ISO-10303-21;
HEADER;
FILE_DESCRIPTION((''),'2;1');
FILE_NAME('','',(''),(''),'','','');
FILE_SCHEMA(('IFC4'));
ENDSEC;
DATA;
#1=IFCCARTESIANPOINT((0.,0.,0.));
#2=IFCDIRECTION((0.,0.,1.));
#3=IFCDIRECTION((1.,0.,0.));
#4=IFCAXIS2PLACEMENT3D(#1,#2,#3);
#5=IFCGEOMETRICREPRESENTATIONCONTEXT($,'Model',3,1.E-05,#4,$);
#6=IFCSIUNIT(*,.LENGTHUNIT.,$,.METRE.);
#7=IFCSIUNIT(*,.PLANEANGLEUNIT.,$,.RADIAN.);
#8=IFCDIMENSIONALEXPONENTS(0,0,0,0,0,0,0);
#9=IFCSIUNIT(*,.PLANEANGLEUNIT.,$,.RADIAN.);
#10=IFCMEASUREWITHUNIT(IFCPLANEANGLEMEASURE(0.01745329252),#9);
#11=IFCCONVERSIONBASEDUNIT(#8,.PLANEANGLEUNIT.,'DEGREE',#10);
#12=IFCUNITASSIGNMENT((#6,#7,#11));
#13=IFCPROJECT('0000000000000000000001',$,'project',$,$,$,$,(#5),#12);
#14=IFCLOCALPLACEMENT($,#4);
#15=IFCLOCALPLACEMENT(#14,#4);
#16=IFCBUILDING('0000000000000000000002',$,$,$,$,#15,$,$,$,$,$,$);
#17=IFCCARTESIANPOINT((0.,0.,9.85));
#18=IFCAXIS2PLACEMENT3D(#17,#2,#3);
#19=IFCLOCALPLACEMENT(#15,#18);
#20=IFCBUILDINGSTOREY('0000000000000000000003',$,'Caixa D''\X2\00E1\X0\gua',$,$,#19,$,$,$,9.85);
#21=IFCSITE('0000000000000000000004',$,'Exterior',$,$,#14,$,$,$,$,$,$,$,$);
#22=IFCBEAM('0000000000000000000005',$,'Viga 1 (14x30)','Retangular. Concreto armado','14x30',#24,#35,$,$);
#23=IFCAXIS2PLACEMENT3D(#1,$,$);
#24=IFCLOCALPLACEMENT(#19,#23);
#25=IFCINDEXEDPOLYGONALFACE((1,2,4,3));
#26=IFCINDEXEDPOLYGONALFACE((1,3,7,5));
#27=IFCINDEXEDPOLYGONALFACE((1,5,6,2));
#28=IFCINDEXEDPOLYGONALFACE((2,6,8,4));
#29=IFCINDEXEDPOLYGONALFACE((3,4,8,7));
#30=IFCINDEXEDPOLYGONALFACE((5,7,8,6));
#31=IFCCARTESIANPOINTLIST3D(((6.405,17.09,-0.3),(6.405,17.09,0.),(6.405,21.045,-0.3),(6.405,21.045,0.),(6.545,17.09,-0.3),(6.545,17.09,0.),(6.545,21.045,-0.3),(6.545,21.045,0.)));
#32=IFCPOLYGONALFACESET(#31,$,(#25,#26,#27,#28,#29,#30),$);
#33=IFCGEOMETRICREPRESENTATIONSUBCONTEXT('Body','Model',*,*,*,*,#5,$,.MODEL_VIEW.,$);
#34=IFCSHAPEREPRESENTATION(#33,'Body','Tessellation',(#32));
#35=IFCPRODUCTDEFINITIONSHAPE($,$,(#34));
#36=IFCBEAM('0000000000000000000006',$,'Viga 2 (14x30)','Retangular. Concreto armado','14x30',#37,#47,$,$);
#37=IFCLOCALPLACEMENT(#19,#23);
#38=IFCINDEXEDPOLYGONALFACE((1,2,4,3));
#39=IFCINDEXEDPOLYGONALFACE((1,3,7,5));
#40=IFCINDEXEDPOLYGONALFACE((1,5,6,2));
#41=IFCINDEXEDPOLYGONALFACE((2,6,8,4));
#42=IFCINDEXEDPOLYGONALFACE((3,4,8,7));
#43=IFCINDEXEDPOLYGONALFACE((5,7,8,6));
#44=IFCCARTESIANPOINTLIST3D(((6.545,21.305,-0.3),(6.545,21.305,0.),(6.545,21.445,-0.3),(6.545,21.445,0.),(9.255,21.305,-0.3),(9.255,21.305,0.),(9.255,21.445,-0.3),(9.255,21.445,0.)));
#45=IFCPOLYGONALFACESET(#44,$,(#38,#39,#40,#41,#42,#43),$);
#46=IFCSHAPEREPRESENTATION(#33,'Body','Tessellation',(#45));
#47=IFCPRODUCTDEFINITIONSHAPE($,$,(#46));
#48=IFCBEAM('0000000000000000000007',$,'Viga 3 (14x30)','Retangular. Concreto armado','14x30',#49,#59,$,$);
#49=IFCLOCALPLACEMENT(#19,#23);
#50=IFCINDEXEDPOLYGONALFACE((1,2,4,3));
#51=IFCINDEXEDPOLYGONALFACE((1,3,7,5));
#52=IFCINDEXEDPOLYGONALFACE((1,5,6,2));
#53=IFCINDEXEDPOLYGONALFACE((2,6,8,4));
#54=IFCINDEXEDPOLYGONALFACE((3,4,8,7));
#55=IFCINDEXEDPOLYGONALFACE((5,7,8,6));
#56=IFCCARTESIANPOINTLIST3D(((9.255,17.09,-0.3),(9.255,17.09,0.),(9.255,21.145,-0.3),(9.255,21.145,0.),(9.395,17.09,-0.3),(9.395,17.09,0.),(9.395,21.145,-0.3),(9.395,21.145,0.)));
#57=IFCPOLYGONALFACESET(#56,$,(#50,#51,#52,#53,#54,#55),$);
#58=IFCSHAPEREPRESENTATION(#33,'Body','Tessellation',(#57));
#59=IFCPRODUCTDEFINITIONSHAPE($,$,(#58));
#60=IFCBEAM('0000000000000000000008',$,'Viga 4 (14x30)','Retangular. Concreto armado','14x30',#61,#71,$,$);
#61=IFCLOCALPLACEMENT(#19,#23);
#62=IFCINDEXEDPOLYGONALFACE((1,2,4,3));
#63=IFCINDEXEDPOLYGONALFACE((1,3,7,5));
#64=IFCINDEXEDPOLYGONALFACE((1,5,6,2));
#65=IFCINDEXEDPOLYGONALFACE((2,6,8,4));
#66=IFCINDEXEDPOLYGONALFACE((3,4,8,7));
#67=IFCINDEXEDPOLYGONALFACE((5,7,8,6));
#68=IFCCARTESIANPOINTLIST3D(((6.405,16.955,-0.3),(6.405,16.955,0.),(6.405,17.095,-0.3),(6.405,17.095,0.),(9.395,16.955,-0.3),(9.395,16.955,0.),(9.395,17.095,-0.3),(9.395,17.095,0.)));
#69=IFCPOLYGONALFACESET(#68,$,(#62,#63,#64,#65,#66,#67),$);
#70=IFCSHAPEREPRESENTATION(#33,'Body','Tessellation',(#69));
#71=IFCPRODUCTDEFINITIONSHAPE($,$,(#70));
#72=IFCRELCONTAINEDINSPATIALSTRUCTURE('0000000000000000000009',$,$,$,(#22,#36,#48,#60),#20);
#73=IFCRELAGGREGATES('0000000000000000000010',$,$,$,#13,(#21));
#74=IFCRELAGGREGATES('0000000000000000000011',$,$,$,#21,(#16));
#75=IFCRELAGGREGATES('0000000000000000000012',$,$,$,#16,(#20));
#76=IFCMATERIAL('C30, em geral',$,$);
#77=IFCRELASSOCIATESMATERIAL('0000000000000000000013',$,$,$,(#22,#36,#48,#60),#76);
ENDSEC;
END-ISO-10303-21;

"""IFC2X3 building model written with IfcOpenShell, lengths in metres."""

from ifc_helpers import new_model, entity, si_unit, converted_unit, frame, frame_2d, origin_with_axes, place, context, subcontext, project, spatial, rectangle, extrude, material, element, save


model = new_model("IFC2X3")

# Units and contexts
model_context = context("Model", 3, precision=1e-05, world=origin_with_axes())
body_context = subcontext(model_context, "Body", "Model", "MODEL_VIEW")
ifc_project = project(units=[si_unit("LENGTHUNIT", "METRE"), si_unit("PLANEANGLEUNIT", "RADIAN"), converted_unit("PLANEANGLEUNIT", "DEGREE", entity("IfcPlaneAngleMeasure", 0.01745329252), si_unit("PLANEANGLEUNIT", "RADIAN"), dimensions=[0, 0, 0, 0, 0, 0, 0])], contexts=[model_context])

# Site, building, storey
site_placement = place(None, origin_with_axes())
site = spatial("IfcSite", under=ifc_project, at=site_placement, Name="Exterior")
building_placement = place(site_placement, origin_with_axes())
building = spatial("IfcBuilding", under=site, at=building_placement)
storey_placement = place(building_placement, frame((0.0, 0.0, 9.85), z_axis=(0.0, 0.0, 1.0), x_axis=(1.0, 0.0, 0.0)))
storey = spatial("IfcBuildingStorey", under=building, at=storey_placement, Name="Caixa D'água", Elevation=9.85)

# Beams
ifc_material = material(Name="C30, em geral")
beam_1_placement = place(storey_placement, frame((6.475, 21.045, 0.0), z_axis=(0.0, -1.0, 0.0), x_axis=(1.0, 0.0, 0.0)))
element("IfcBeam", 1, at=beam_1_placement, inside=storey, material=ifc_material, Name="Viga 1 (14x30)", Description="Retangular. Concreto armado", ObjectType="14x30", context=body_context, shape_type="SweptSolid", body=[
    extrude(rectangle(XDim=0.14, YDim=0.3, at=frame_2d((0.0, -0.15), x_axis=(1.0, 0.0))), origin_with_axes(), (0.0, 0.0, 1.0), 3.955),
])
beam_2_placement = place(storey_placement, frame((9.255, 21.375, 0.0), z_axis=(-1.0, 0.0, 0.0), x_axis=(0.0, -1.0, 0.0)))
element("IfcBeam", 2, at=beam_2_placement, inside=storey, material=ifc_material, Name="Viga 2 (14x30)", Description="Retangular. Concreto armado", ObjectType="14x30", context=body_context, shape_type="SweptSolid", body=[
    extrude(rectangle(XDim=0.14, YDim=0.3, at=frame_2d((0.0, -0.15), x_axis=(1.0, 0.0))), origin_with_axes(), (0.0, 0.0, 1.0), 2.71),
])
beam_3_placement = place(storey_placement, frame((9.325, 21.145, 0.0), z_axis=(0.0, -1.0, 0.0), x_axis=(1.0, 0.0, 0.0)))
element("IfcBeam", 3, at=beam_3_placement, inside=storey, material=ifc_material, Name="Viga 3 (14x30)", Description="Retangular. Concreto armado", ObjectType="14x30", context=body_context, shape_type="SweptSolid", body=[
    extrude(rectangle(XDim=0.14, YDim=0.3, at=frame_2d((0.0, -0.15), x_axis=(1.0, 0.0))), origin_with_axes(), (0.0, 0.0, 1.0), 4.055),
])
beam_4_placement = place(storey_placement, frame((6.405, 17.025, 0.0), z_axis=(1.0, 0.0, 0.0), x_axis=(0.0, 1.0, 0.0)))
element("IfcBeam", 4, at=beam_4_placement, inside=storey, material=ifc_material, Name="Viga 4 (14x30)", Description="Retangular. Concreto armado", ObjectType="14x30", context=body_context, shape_type="SweptSolid", body=[
    extrude(rectangle(XDim=0.14, YDim=0.3, at=frame_2d((0.0, -0.15), x_axis=(1.0, 0.0))), origin_with_axes(), (0.0, 0.0, 1.0), 2.99),
])

save(model, "model.ifc")
